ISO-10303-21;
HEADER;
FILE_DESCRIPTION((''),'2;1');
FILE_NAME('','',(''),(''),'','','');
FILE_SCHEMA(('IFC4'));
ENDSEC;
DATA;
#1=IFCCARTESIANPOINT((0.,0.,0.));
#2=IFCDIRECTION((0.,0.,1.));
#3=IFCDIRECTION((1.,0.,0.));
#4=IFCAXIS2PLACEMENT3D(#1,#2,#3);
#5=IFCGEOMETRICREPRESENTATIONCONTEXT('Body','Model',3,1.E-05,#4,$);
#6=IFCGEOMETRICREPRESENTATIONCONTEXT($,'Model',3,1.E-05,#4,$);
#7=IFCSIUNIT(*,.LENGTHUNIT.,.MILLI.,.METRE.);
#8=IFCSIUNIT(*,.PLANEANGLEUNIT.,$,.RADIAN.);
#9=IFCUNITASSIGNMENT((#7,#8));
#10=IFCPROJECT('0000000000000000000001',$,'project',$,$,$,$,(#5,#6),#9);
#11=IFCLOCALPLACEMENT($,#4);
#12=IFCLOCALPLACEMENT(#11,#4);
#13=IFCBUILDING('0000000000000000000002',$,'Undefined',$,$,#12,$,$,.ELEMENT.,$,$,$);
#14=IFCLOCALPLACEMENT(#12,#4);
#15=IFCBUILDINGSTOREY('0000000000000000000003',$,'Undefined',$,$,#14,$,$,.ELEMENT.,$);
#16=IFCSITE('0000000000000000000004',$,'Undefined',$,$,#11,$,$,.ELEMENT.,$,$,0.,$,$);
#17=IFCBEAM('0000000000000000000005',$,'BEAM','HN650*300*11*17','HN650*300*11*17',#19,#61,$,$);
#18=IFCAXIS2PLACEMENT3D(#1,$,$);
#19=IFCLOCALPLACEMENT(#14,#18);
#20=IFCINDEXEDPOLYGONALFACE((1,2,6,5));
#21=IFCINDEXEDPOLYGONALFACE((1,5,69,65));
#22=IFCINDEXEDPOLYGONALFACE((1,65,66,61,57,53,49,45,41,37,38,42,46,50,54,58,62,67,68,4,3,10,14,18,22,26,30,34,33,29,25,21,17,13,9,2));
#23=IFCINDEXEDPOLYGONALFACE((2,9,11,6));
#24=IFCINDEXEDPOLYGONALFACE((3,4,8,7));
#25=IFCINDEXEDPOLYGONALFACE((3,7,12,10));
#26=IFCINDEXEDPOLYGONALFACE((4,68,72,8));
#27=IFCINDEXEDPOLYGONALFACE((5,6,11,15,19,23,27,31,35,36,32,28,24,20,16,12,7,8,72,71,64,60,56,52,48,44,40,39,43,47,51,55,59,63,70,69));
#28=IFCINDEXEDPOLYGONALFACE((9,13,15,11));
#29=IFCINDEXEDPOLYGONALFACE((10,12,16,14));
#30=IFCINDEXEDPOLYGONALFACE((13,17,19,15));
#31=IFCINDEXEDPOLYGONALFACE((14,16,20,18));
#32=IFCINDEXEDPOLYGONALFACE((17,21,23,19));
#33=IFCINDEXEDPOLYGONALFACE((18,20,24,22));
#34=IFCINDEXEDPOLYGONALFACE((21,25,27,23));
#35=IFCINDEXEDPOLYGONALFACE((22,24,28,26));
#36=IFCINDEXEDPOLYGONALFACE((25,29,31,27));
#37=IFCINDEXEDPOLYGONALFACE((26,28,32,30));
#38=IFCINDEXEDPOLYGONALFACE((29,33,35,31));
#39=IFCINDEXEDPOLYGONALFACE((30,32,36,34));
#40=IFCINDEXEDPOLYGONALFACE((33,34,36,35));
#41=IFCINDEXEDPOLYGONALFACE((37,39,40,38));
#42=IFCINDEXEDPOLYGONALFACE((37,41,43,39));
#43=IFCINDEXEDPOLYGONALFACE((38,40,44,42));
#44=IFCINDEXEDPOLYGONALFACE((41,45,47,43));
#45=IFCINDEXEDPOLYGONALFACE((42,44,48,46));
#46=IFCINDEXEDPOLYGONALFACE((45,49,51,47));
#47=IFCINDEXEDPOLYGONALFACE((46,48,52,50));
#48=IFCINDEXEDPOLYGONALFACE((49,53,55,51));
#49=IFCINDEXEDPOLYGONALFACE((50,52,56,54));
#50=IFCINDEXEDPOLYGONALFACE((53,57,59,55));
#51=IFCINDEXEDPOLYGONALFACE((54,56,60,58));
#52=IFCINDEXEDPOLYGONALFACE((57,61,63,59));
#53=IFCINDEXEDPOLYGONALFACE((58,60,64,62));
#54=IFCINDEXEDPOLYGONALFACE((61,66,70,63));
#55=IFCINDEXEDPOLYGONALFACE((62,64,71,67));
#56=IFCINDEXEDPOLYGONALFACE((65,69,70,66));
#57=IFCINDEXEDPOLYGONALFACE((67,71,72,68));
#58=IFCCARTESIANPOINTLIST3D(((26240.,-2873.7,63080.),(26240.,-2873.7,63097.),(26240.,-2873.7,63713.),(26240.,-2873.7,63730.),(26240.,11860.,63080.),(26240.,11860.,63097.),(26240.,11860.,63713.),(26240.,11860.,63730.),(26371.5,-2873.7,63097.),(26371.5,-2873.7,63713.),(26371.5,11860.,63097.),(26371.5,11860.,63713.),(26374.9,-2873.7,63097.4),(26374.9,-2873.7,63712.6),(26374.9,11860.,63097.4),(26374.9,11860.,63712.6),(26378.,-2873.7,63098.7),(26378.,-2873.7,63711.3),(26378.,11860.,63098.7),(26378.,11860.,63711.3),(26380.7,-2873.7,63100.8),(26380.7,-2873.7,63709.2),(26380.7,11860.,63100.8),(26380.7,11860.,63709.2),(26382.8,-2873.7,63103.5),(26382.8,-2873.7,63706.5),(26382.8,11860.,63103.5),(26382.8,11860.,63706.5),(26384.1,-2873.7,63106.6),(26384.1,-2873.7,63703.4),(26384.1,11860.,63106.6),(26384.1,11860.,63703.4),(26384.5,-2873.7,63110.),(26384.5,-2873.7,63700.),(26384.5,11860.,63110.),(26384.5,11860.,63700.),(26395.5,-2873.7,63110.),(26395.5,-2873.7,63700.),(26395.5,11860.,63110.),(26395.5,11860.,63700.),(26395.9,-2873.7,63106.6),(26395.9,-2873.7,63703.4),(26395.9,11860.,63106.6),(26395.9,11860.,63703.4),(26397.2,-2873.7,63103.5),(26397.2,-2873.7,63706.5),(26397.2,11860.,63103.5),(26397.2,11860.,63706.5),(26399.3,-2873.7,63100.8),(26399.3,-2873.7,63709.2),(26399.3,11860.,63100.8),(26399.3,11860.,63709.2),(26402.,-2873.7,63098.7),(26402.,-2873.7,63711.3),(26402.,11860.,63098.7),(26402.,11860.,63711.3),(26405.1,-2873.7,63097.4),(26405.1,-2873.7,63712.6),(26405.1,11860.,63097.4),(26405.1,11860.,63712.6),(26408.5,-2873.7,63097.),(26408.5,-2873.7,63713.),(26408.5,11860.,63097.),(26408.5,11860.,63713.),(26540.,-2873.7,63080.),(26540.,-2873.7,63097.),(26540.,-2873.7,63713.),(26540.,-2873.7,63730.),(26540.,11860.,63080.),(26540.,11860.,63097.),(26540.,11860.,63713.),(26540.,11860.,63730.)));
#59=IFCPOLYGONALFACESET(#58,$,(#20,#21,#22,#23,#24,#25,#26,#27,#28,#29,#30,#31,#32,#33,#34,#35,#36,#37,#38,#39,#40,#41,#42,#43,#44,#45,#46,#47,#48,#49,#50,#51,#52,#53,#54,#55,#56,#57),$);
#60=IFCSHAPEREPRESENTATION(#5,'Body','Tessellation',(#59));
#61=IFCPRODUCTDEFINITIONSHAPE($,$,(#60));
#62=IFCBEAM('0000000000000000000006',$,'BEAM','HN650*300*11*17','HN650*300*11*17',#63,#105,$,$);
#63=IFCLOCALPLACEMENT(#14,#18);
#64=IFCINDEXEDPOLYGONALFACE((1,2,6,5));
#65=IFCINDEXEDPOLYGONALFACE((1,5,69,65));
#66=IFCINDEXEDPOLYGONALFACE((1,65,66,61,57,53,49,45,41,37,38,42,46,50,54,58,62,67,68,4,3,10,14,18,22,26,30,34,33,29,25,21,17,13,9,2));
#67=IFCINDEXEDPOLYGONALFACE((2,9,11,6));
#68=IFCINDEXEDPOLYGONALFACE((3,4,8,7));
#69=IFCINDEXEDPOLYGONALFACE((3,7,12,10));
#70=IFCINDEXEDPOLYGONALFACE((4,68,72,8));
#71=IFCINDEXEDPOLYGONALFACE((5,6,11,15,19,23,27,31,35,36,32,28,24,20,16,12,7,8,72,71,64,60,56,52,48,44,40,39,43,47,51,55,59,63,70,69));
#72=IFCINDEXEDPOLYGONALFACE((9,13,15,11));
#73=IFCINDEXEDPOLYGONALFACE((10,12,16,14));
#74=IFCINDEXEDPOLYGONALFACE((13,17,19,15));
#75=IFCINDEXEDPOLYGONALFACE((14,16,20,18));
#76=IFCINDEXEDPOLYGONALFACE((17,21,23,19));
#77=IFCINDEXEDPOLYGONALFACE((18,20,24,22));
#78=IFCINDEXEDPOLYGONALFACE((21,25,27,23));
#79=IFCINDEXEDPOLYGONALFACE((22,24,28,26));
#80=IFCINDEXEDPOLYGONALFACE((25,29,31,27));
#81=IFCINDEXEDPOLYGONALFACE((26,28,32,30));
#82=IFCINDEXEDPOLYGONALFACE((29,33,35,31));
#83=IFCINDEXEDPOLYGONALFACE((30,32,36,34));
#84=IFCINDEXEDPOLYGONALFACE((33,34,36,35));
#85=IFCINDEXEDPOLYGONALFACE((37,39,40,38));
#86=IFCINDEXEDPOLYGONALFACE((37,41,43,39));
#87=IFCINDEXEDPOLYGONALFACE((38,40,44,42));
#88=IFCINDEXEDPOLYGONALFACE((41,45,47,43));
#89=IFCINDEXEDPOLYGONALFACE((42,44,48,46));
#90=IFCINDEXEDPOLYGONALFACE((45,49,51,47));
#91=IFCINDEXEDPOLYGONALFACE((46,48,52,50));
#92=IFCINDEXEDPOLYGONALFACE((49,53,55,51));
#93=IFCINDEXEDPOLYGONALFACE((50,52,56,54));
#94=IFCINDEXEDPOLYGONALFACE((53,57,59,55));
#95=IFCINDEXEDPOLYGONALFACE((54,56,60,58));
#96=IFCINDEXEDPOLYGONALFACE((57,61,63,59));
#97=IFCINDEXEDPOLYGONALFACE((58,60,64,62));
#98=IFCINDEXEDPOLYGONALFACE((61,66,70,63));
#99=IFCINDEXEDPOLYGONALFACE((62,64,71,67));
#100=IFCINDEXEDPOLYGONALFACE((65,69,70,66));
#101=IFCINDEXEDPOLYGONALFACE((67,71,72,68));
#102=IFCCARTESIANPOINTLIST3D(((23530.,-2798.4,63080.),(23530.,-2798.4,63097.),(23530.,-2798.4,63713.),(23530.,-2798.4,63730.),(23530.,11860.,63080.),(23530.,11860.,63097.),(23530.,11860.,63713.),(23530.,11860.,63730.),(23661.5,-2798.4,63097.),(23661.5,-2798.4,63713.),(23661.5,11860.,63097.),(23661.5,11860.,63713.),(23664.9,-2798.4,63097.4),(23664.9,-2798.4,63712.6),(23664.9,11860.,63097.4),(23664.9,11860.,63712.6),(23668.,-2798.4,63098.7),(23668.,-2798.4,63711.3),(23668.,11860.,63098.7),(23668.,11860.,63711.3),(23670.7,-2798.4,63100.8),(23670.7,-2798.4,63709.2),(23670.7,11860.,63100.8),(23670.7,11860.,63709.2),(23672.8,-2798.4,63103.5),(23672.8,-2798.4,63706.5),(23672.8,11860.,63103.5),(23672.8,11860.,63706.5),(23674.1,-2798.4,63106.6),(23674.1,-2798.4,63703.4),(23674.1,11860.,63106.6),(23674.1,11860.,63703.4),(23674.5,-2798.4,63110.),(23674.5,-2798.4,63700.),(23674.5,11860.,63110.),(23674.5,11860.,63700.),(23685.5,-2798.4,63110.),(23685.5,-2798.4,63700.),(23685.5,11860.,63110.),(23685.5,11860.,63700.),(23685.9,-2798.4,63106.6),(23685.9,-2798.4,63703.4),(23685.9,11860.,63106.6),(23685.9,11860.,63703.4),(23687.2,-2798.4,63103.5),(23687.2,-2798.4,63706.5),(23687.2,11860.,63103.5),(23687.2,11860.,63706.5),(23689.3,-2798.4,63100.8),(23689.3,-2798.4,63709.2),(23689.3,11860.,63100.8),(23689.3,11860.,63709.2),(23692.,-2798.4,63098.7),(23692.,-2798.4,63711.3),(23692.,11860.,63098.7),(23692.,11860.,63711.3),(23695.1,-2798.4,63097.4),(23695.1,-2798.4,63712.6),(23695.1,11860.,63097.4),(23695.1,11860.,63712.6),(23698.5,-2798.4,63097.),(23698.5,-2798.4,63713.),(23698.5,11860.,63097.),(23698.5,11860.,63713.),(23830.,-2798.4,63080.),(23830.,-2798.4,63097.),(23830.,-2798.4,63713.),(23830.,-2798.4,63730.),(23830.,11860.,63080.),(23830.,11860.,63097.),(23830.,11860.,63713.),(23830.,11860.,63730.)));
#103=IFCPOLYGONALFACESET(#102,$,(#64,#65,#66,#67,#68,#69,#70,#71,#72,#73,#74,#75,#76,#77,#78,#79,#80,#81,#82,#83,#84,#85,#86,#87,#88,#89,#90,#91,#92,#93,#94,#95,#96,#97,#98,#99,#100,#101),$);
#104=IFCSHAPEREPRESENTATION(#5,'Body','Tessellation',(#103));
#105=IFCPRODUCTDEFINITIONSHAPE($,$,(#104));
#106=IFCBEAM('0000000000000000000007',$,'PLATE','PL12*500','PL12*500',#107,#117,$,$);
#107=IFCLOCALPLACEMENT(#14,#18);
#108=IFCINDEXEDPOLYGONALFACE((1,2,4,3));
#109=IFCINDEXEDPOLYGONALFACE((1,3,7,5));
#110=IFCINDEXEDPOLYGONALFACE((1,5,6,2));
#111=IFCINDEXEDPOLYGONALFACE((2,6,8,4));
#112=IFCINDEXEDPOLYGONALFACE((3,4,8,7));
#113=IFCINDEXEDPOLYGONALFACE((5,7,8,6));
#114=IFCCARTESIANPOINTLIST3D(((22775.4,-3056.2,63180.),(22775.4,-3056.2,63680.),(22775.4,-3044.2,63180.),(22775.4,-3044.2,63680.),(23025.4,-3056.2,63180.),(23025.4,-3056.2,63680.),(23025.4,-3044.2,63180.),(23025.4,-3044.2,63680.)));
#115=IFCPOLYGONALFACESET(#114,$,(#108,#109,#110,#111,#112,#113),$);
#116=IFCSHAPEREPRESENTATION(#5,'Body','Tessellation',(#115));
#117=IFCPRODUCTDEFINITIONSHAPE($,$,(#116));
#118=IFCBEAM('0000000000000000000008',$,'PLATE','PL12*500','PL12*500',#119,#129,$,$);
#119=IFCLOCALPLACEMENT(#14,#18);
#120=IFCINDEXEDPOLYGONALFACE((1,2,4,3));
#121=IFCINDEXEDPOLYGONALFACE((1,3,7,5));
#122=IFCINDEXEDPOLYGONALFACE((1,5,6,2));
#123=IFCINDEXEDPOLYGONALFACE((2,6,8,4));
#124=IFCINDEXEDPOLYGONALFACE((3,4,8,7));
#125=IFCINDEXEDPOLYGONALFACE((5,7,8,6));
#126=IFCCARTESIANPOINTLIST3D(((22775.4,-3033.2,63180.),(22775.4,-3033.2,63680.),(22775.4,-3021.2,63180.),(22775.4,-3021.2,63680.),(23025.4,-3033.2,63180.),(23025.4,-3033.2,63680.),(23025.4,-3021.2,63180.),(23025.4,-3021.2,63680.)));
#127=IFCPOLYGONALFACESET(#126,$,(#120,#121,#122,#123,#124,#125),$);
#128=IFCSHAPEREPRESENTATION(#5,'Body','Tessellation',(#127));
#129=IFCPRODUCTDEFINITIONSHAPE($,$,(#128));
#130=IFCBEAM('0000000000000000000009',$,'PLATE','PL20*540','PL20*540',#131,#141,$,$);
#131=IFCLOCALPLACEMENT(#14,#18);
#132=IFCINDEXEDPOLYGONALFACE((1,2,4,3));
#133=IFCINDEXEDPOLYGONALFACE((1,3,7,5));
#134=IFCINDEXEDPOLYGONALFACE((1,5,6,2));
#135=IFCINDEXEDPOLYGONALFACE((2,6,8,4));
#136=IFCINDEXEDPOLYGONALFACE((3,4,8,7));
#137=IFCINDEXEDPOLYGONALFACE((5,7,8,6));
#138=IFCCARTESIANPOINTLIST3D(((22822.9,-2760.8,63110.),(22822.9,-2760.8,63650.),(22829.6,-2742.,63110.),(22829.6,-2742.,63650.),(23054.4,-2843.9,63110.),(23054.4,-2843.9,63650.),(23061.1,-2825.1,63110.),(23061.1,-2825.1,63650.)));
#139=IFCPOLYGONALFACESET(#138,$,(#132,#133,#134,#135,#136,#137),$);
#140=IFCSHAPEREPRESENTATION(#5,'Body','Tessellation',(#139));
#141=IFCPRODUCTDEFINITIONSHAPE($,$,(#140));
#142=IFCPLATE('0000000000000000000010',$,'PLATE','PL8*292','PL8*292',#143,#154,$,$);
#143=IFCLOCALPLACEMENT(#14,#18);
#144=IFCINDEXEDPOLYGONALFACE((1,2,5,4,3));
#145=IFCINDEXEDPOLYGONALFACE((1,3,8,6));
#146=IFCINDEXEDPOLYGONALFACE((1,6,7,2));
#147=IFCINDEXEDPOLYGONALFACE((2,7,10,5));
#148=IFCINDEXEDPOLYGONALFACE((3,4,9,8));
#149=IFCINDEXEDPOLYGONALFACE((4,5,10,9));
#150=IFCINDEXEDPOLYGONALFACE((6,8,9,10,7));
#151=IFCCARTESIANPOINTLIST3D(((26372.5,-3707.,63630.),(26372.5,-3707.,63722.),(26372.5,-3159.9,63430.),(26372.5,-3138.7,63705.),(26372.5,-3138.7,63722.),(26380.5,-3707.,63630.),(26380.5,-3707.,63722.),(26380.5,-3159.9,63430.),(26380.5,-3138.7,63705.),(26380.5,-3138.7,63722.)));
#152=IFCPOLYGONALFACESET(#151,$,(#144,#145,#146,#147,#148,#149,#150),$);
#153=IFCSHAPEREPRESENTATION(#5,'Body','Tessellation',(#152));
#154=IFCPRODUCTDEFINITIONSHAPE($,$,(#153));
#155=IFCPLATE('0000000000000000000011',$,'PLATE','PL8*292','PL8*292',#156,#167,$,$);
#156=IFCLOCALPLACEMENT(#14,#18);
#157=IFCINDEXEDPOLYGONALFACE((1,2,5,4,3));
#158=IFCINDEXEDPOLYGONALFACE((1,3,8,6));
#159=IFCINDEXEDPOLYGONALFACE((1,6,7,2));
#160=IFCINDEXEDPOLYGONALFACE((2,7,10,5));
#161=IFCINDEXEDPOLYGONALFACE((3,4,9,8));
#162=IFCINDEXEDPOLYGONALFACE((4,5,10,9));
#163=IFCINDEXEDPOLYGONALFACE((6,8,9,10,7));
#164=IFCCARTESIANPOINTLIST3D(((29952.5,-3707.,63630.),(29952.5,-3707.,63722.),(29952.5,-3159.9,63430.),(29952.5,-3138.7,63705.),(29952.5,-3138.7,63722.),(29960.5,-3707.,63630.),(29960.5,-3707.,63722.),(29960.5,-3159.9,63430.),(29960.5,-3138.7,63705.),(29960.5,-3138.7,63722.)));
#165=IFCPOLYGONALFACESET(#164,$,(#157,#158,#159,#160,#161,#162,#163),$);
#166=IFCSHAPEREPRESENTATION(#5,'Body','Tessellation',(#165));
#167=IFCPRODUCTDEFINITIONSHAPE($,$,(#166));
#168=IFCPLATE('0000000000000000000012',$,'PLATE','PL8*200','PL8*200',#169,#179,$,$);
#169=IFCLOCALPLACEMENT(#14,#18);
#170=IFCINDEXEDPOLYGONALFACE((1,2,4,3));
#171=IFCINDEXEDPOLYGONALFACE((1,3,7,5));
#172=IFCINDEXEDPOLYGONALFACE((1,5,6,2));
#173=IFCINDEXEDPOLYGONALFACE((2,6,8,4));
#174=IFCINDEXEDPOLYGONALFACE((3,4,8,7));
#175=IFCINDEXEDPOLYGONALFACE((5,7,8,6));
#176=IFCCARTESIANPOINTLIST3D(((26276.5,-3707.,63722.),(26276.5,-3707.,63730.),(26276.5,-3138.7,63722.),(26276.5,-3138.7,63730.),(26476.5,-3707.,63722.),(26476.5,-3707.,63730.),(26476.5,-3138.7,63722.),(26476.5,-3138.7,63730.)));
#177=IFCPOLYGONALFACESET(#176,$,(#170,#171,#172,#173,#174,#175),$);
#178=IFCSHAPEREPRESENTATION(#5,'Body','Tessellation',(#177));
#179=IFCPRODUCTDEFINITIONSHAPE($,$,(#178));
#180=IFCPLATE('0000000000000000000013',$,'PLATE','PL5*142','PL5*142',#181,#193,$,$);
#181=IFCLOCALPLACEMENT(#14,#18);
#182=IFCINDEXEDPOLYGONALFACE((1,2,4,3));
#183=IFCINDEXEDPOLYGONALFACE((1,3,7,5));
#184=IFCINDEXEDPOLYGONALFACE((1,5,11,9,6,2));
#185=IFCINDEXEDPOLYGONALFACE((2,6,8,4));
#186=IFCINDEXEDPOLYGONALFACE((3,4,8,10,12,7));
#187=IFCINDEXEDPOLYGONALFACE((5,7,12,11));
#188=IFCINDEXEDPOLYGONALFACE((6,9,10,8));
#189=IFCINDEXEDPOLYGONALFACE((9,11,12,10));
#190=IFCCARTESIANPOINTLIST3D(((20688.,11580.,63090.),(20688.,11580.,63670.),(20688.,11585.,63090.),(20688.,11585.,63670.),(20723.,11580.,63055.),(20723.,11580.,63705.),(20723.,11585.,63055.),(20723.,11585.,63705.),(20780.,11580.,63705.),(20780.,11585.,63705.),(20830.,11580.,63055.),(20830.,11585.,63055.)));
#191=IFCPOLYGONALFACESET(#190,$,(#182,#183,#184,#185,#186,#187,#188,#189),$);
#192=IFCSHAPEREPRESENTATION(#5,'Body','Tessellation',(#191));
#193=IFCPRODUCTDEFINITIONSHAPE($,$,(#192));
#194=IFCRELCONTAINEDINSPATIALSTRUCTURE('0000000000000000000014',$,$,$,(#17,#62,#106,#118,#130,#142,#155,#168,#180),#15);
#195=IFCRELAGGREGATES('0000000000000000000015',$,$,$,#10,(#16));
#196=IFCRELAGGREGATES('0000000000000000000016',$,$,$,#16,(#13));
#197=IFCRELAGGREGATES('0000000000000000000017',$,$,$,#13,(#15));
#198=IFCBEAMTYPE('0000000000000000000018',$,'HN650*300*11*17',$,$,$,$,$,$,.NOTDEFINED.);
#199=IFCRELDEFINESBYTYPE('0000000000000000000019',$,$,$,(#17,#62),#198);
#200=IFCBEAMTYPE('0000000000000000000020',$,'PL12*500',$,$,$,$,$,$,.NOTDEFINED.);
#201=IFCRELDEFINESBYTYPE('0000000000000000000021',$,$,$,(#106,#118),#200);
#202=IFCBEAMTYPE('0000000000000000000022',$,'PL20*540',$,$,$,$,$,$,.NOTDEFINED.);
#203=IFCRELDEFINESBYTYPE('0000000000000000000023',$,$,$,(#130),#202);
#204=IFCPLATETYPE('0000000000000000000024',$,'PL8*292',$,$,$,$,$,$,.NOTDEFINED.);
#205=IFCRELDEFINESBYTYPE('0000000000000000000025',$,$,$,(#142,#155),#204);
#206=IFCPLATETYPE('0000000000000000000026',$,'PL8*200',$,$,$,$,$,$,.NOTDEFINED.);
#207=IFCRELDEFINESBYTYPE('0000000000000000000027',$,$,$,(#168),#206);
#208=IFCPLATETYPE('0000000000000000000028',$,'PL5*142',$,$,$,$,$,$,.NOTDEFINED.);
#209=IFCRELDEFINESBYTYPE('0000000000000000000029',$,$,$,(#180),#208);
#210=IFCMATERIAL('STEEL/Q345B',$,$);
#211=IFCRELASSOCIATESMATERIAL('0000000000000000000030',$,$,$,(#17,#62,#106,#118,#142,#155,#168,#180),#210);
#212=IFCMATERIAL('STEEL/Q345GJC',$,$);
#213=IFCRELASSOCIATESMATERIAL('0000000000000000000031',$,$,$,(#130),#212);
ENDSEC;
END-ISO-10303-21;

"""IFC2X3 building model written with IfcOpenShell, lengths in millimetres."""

from ifc_helpers import new_model, si_unit, frame, origin_with_axes, origin_2d_with_axis, place, context, project, spatial, polyline, rectangle, i_section, outline, extrude, material, type_object, element, save


model = new_model("IFC2X3")

# Units and contexts
model_context_1 = context("Model", 3, precision=1e-05, world=origin_with_axes(), identifier="Body")
model_context_2 = context("Model", 3, precision=1e-05, world=origin_with_axes())
ifc_project = project(units=[si_unit("LENGTHUNIT", "METRE", prefix="MILLI"), si_unit("PLANEANGLEUNIT", "RADIAN")], contexts=[model_context_1, model_context_2])

# Site, building, storey
site_placement = place(None, origin_with_axes())
site = spatial("IfcSite", under=ifc_project, at=site_placement, Name="Undefined", CompositionType="ELEMENT", RefElevation=0.0)
building_placement = place(site_placement, origin_with_axes())
building = spatial("IfcBuilding", under=site, at=building_placement, Name="Undefined", CompositionType="ELEMENT")
storey_placement = place(building_placement, origin_with_axes())
storey = spatial("IfcBuildingStorey", under=building, at=storey_placement, Name="Undefined", CompositionType="ELEMENT")

# Beams
ifc_material_1 = material(Name="STEEL/Q345B")
beam_type_1 = type_object("IfcBeamType", Name="HN650*300*11*17", PredefinedType="NOTDEFINED")
beam_1_placement = place(storey_placement, frame((26390.0, 11880.0, 63405.0), z_axis=(0.0, 0.0, 1.0), x_axis=(0.0, -1.0, 0.0)))
element("IfcBeam", 1, at=beam_1_placement, inside=storey, type_object=beam_type_1, material=ifc_material_1, Name="BEAM", Description="HN650*300*11*17", ObjectType="HN650*300*11*17", context=model_context_1, shape_type="SweptSolid", body=[
    extrude(i_section(OverallWidth=300.0, OverallDepth=650.0, WebThickness=11.0, FlangeThickness=17.0, FilletRadius=13.0, at=origin_2d_with_axis()), frame((14753.7, 0.0, 0.0), z_axis=(-1.0, 0.0, 0.0), x_axis=(0.0, -1.0, 0.0)), (0.0, 0.0, 1.0), 14733.7),
])
beam_2_placement = place(storey_placement, frame((23680.0, 11880.0, 63405.0), z_axis=(0.0, 0.0, 1.0), x_axis=(0.0, -1.0, 0.0)))
element("IfcBeam", 2, at=beam_2_placement, inside=storey, type_object=beam_type_1, material=ifc_material_1, Name="BEAM", Description="HN650*300*11*17", ObjectType="HN650*300*11*17", context=model_context_1, shape_type="SweptSolid", body=[
    extrude(i_section(OverallWidth=300.0, OverallDepth=650.0, WebThickness=11.0, FlangeThickness=17.0, FilletRadius=13.0, at=origin_2d_with_axis()), frame((14678.4, 0.0, 0.0), z_axis=(-1.0, 0.0, 0.0), x_axis=(0.0, -1.0, 0.0)), (0.0, 0.0, 1.0), 14658.4),
])
beam_type_2 = type_object("IfcBeamType", Name="PL12*500", PredefinedType="NOTDEFINED")
for number, where, z_axis, x_axis, name in (
    (3, (23025.4, -3050.2, 63430.0), (0.0, 0.0, 1.0), (-1.0, 0.0, 0.0), "PLATE"),
    (4, (23025.4, -3027.2, 63430.0), (0.0, 0.0, 1.0), (-1.0, 0.0, 0.0), "PLATE"),
):
    element("IfcBeam", number, at=place(storey_placement, frame(where, z_axis=z_axis, x_axis=x_axis)), inside=storey, type_object=beam_type_2, material=ifc_material_1, Name=name, Description="PL12*500", ObjectType="PL12*500", context=model_context_1, shape_type="SweptSolid", body=[
        extrude(rectangle(XDim=12.0, YDim=500.0, at=origin_2d_with_axis()), frame((250.0, 0.0, 0.0), z_axis=(-1.0, 0.0, 0.0), x_axis=(0.0, -1.0, 0.0)), (0.0, 0.0, 1.0), 250.0),
    ])
ifc_material_2 = material(Name="STEEL/Q345GJC")
beam_type_3 = type_object("IfcBeamType", Name="PL20*540", PredefinedType="NOTDEFINED")
beam_3_placement = place(storey_placement, frame((23057.8, -2834.5, 63380.0), z_axis=(0.0, 0.0, 1.0), x_axis=(-0.941212, 0.337816, 0.0)))
element("IfcBeam", 5, at=beam_3_placement, inside=storey, type_object=beam_type_3, material=ifc_material_2, Name="PLATE", Description="PL20*540", ObjectType="PL20*540", context=model_context_1, shape_type="SweptSolid", body=[
    extrude(rectangle(XDim=20.0, YDim=540.0, at=origin_2d_with_axis()), frame((246.0, 0.0, 0.0), z_axis=(-1.0, 0.0, 0.0), x_axis=(0.0, -1.0, 0.0)), (0.0, 0.0, 1.0), 246.0),
])

# Plates
plate_type_1 = type_object("IfcPlateType", Name="PL8*292", PredefinedType="NOTDEFINED")
for number, where, z_axis, x_axis, name in (
    (6, (26376.5, -3138.7, 63722.0), (-1.0, 0.0, 0.0), (0.0, 0.0, -1.0), "PLATE"),
    (7, (29956.5, -3138.7, 63722.0), (-1.0, 0.0, 0.0), (0.0, 0.0, -1.0), "PLATE"),
):
    element("IfcPlate", number, at=place(storey_placement, frame(where, z_axis=z_axis, x_axis=x_axis)), inside=storey, type_object=plate_type_1, material=ifc_material_1, Name=name, Description="PL8*292", ObjectType="PL8*292", context=model_context_1, shape_type="SweptSolid", body=[
        extrude(outline(polyline([(0.0, 0.0), (17.0, 0.0), (292.0, 21.2), (92.0, 568.3), (0.0, 568.3), (0.0, 0.0)])), frame((0.0, 0.0, -4.0), z_axis=(0.0, 0.0, 1.0), x_axis=(1.0, 0.0, 0.0)), (0.0, 0.0, 1.0), 8.0),
    ])
plate_type_2 = type_object("IfcPlateType", Name="PL8*200", PredefinedType="NOTDEFINED")
plate_1_placement = place(storey_placement, frame((26476.5, -3707.0, 63726.0), z_axis=(0.0, 0.0, 1.0), x_axis=(0.0, 1.0, 0.0)))
element("IfcPlate", 8, at=plate_1_placement, inside=storey, type_object=plate_type_2, material=ifc_material_1, Name="PLATE", Description="PL8*200", ObjectType="PL8*200", context=model_context_1, shape_type="SweptSolid", body=[
    extrude(outline(polyline([(0.0, 0.0), (568.3, 0.0), (568.3, 200.0), (0.0, 200.0), (0.0, 0.0)])), frame((0.0, 0.0, -4.0), z_axis=(0.0, 0.0, 1.0), x_axis=(1.0, 0.0, 0.0)), (0.0, 0.0, 1.0), 8.0),
])
plate_type_3 = type_object("IfcPlateType", Name="PL5*142", PredefinedType="NOTDEFINED")
plate_2_placement = place(storey_placement, frame((20830.0, 11582.5, 63055.0), z_axis=(0.0, 1.0, 0.0), x_axis=(-1.0, 0.0, 0.0)))
element("IfcPlate", 9, at=plate_2_placement, inside=storey, type_object=plate_type_3, material=ifc_material_1, Name="PLATE", Description="PL5*142", ObjectType="PL5*142", context=model_context_1, shape_type="SweptSolid", body=[
    extrude(outline(polyline([(0.0, 0.0), (107.0, 0.0), (142.0, 35.0), (142.0, 615.0), (107.0, 650.0), (50.0, 650.0), (0.0, 0.0)])), frame((0.0, 0.0, -2.5), z_axis=(0.0, 0.0, 1.0), x_axis=(1.0, 0.0, 0.0)), (0.0, 0.0, 1.0), 5.0),
])

save(model, "model.ifc")
